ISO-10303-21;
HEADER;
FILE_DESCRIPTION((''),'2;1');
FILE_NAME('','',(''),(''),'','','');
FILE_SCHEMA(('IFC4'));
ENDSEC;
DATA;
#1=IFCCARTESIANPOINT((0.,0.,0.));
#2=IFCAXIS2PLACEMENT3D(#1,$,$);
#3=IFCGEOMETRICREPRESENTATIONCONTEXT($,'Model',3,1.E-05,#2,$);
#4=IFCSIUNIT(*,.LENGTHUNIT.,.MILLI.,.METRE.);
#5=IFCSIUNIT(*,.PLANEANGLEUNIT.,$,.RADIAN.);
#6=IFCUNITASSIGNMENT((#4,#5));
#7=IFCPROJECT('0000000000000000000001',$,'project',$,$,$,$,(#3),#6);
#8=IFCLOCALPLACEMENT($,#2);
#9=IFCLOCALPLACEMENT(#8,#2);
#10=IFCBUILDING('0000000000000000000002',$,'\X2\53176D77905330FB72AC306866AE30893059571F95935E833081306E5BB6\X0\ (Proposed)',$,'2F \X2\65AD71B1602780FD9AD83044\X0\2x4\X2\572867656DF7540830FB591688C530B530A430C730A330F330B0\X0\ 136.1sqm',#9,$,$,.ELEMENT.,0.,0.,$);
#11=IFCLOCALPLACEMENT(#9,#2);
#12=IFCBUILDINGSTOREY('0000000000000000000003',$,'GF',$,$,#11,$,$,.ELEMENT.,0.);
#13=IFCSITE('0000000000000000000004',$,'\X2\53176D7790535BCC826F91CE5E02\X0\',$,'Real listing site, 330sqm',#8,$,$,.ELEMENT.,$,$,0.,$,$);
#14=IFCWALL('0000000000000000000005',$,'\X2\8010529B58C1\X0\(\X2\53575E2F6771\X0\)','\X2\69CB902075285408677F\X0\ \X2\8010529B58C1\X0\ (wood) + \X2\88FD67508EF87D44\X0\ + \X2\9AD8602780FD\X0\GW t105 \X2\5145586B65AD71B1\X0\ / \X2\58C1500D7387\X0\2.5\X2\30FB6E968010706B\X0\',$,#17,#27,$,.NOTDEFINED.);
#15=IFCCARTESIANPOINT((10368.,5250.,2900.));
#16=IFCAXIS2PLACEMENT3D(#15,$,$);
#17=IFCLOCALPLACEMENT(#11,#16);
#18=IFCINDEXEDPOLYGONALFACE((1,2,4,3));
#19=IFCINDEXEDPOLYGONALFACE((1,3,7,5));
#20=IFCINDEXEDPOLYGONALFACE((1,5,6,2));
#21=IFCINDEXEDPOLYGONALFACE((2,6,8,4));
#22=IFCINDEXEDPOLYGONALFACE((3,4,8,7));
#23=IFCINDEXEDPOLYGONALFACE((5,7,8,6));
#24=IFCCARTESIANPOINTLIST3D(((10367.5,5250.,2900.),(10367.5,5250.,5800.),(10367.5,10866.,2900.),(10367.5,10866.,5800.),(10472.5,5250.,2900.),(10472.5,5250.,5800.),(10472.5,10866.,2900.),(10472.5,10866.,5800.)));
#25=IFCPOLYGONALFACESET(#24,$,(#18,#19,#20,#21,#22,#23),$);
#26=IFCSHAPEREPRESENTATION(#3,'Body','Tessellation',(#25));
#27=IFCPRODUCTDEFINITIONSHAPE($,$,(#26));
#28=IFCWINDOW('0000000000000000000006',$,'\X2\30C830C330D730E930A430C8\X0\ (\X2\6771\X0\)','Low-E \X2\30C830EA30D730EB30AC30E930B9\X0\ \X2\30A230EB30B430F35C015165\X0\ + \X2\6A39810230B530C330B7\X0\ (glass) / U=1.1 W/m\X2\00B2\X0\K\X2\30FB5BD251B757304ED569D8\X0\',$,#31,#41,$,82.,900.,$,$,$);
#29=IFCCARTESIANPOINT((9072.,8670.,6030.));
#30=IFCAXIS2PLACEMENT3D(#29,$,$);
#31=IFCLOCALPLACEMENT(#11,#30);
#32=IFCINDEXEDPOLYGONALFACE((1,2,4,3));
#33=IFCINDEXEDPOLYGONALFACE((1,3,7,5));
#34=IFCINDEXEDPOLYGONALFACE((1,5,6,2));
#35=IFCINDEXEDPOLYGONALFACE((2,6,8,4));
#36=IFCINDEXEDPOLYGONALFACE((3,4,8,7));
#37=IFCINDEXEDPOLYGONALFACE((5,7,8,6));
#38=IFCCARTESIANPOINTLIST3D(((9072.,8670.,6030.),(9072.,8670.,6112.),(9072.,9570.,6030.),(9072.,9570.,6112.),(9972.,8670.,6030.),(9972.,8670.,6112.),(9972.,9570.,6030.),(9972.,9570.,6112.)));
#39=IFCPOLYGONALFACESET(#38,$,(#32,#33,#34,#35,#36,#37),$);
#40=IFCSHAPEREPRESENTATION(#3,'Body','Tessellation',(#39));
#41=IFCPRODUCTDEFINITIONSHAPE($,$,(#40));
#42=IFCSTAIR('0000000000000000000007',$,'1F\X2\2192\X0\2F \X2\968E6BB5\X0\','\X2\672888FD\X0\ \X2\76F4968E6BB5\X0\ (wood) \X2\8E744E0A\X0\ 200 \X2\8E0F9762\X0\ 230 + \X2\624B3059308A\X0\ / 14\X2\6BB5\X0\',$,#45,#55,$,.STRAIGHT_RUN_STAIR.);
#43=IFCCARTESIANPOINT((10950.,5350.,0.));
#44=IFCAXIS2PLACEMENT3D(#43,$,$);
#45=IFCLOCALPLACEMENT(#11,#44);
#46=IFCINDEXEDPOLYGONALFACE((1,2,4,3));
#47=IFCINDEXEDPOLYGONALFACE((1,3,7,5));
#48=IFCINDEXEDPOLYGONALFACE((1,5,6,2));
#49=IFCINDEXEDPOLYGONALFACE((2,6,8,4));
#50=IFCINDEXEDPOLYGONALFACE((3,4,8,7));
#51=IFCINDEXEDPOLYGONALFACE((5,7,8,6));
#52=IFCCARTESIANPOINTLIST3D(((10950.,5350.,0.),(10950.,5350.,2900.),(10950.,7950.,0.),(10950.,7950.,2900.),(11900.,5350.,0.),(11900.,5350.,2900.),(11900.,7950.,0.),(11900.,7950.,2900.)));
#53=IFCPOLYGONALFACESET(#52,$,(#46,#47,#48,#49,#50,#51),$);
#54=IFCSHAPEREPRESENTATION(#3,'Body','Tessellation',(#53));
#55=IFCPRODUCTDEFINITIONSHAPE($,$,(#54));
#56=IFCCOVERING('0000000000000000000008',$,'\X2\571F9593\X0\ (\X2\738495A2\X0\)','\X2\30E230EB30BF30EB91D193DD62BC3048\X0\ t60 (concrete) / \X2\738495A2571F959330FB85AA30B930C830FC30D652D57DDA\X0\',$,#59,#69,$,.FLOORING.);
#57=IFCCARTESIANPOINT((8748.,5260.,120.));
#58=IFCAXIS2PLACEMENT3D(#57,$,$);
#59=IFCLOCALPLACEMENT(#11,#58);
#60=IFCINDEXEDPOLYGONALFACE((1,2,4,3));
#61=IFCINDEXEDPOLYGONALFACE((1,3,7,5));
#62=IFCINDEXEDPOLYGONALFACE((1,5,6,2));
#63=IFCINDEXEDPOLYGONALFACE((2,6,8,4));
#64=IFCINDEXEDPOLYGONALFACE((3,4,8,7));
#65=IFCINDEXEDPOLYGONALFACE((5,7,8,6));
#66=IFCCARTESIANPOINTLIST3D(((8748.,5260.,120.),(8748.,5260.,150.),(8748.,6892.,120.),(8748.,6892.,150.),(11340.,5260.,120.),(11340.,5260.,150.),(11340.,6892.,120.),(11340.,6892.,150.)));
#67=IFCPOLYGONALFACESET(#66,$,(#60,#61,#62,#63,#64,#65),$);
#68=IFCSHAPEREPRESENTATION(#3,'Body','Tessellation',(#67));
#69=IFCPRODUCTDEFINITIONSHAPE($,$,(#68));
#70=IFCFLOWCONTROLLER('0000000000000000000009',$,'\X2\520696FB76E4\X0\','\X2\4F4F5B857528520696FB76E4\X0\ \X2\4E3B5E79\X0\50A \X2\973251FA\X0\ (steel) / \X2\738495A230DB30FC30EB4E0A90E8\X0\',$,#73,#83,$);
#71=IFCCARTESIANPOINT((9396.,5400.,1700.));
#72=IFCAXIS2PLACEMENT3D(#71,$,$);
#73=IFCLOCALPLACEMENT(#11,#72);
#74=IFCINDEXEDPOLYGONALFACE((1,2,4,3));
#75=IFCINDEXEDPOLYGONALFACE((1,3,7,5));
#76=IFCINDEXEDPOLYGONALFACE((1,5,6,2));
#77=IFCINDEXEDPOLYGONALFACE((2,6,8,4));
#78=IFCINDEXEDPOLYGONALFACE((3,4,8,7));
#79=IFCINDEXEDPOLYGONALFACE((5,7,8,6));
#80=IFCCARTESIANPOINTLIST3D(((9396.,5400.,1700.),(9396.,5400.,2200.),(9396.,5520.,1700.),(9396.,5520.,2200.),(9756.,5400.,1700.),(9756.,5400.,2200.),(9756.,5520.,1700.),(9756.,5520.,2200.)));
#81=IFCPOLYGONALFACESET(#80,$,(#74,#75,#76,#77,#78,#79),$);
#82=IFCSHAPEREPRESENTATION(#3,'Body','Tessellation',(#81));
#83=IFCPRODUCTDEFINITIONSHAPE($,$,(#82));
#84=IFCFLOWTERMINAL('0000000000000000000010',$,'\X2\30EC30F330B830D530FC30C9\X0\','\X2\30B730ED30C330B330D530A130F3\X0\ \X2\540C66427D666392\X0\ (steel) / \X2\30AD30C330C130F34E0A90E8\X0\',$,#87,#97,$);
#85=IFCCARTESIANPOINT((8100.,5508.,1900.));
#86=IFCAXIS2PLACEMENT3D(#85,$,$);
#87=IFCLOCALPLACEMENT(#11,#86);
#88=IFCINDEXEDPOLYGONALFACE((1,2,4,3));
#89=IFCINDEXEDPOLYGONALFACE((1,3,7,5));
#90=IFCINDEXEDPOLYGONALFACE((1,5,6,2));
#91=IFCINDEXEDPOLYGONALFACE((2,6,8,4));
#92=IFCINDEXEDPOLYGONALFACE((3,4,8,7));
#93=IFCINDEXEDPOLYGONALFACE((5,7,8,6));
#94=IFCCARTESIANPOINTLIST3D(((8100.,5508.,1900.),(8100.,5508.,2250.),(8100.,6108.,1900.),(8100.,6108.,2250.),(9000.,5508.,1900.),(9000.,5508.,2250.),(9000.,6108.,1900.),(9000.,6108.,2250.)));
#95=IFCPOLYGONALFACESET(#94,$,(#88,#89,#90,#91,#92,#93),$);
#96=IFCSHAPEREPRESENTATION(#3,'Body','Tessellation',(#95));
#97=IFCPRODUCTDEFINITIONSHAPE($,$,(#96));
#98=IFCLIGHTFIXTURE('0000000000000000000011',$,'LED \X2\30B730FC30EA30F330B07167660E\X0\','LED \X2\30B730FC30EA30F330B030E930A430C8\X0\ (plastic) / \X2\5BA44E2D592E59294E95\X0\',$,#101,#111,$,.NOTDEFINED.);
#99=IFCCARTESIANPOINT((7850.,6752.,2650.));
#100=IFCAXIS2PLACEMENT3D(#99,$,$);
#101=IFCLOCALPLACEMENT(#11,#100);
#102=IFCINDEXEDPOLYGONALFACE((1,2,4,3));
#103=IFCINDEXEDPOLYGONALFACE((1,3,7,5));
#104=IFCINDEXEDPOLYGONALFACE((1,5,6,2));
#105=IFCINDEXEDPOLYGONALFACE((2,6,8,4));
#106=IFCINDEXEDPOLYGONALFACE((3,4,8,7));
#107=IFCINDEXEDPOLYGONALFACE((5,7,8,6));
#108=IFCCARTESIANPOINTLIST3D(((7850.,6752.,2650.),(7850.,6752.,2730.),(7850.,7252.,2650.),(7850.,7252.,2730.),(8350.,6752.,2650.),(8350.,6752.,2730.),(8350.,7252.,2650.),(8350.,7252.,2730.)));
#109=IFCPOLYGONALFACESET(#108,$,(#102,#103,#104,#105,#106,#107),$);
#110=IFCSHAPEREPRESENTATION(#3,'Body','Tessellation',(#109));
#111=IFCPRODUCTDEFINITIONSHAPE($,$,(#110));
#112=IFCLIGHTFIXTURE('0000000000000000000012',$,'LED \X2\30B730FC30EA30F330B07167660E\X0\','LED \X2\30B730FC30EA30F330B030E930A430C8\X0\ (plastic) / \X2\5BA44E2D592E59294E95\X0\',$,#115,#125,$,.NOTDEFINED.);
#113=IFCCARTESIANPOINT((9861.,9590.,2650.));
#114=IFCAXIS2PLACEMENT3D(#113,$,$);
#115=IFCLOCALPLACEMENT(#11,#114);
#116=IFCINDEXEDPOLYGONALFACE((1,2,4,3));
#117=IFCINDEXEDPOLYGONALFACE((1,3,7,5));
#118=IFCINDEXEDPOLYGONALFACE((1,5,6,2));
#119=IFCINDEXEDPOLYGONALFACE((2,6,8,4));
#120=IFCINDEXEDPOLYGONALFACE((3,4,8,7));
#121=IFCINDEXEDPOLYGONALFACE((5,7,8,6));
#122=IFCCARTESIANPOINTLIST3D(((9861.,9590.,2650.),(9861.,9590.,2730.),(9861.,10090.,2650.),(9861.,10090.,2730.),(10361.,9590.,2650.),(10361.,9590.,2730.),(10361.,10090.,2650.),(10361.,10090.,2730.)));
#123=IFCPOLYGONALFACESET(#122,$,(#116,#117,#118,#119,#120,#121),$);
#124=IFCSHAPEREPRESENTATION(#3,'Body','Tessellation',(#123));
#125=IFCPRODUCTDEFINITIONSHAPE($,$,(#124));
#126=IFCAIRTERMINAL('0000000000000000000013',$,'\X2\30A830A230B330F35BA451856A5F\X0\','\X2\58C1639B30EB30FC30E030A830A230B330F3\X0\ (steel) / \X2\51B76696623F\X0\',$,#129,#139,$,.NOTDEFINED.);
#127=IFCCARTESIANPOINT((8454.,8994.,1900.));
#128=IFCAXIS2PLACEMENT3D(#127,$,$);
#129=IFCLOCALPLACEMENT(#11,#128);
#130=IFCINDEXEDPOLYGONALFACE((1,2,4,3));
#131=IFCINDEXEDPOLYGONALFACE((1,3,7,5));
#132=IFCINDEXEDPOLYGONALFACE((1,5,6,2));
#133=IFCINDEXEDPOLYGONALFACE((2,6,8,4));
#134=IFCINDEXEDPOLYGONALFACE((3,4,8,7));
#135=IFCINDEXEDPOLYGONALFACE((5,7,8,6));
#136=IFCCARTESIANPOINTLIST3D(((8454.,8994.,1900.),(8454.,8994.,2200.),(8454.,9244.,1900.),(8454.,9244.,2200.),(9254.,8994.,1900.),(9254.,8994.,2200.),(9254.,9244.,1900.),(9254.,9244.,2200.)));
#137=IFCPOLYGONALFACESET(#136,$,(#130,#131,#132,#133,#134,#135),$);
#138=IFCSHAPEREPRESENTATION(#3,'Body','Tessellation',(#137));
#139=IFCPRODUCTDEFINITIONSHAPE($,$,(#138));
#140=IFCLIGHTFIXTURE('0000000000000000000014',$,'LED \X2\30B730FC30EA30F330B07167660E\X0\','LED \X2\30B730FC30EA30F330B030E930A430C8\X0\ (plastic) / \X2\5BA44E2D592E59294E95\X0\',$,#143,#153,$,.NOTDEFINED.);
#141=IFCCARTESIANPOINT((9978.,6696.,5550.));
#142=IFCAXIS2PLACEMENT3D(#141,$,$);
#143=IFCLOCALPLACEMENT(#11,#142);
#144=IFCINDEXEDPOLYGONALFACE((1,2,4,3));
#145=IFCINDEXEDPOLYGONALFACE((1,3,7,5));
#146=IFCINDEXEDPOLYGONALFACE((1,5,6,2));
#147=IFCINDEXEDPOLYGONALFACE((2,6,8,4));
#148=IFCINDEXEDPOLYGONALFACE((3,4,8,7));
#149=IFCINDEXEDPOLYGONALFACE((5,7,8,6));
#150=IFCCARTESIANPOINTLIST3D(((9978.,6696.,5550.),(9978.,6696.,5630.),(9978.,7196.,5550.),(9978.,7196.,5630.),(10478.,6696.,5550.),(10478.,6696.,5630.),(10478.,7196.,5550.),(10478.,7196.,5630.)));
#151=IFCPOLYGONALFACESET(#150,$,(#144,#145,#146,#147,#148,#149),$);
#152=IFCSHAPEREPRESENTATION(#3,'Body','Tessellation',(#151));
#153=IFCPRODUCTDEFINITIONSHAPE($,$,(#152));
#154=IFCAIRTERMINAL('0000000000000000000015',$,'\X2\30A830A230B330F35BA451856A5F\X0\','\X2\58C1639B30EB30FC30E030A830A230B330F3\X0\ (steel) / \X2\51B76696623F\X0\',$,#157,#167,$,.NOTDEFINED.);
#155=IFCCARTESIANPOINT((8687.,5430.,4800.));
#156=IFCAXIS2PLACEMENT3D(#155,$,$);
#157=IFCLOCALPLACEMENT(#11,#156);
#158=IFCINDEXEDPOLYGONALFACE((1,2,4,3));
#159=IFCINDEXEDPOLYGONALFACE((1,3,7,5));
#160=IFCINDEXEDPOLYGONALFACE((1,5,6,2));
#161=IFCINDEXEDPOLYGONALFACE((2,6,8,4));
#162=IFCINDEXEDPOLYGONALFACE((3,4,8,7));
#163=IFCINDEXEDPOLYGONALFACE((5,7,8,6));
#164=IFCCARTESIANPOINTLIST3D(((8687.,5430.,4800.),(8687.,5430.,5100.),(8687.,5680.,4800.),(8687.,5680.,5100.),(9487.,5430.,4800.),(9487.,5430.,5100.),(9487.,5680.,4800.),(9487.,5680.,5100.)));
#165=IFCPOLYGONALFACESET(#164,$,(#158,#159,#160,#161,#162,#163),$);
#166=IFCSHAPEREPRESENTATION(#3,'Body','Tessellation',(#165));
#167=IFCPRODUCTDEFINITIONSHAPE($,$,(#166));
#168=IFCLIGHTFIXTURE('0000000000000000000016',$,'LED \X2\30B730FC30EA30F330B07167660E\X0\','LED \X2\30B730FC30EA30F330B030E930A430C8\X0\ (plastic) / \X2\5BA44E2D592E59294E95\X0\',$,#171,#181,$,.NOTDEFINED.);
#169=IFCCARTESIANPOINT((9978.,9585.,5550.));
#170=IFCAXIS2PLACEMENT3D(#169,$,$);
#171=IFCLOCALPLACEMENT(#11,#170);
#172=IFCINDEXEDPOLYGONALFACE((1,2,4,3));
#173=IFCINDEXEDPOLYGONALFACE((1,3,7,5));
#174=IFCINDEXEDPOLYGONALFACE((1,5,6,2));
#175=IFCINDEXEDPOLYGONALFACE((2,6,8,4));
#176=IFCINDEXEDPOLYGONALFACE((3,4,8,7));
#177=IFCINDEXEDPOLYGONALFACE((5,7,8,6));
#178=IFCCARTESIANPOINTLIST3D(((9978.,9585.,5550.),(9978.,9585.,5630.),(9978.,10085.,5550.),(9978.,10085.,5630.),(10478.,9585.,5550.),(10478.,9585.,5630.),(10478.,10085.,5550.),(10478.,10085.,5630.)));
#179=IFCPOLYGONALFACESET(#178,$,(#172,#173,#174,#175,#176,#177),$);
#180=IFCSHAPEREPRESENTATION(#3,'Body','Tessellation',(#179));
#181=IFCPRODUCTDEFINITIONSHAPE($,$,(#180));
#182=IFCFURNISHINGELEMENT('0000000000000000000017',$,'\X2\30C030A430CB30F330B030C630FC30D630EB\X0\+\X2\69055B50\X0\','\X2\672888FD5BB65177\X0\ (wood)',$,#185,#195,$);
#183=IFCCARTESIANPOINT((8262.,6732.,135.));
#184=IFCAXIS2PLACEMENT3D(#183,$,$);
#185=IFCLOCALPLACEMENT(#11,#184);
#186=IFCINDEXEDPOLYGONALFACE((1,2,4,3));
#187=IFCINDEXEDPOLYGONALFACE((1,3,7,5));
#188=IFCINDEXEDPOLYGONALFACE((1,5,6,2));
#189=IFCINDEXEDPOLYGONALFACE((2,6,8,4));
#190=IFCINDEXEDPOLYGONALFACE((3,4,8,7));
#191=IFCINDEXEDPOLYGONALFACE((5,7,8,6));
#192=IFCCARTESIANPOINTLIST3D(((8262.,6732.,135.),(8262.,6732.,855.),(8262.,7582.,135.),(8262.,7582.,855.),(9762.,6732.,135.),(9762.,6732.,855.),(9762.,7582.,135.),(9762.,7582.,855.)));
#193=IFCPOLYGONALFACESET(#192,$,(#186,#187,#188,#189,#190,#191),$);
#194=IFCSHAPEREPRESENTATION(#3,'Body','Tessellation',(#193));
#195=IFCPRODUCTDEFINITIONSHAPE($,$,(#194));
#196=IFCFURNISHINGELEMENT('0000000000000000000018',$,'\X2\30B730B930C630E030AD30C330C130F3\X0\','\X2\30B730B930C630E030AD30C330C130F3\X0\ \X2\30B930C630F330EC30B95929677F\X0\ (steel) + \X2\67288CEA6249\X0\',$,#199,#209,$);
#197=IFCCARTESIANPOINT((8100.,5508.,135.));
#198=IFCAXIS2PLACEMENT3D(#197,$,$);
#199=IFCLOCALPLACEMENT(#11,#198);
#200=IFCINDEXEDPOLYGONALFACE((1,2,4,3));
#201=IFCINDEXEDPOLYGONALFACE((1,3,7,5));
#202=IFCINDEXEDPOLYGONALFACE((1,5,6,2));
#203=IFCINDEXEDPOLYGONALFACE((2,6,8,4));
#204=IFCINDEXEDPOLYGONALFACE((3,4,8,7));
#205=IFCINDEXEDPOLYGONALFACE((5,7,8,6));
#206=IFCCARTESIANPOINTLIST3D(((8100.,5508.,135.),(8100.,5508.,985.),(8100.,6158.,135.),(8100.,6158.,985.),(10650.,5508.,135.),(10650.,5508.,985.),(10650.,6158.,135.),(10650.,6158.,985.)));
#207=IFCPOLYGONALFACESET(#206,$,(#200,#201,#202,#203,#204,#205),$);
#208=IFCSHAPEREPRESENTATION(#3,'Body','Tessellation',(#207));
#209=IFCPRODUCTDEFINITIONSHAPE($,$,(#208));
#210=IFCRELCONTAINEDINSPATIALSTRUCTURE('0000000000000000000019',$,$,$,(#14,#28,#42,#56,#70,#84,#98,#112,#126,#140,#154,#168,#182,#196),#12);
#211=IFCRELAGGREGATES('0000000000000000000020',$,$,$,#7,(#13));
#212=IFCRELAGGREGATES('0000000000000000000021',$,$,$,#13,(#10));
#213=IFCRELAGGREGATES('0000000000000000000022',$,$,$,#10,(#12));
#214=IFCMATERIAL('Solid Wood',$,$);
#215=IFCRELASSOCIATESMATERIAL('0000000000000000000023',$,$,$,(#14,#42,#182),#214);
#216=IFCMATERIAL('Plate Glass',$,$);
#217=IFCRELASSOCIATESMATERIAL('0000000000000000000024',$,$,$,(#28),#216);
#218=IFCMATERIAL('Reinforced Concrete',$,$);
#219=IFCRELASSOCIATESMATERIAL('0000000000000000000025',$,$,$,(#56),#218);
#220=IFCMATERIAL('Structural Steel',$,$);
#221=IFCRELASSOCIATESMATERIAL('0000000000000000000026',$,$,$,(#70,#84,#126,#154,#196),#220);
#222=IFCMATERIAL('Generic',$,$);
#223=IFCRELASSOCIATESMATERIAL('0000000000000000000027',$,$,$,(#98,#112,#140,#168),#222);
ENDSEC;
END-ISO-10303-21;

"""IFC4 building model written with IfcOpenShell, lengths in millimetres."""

from ifc_helpers import new_model, si_unit, frame, frame_2d, origin, place, context, project, spatial, rectangle, extrude, material, element, save


model = new_model("IFC4")

# Units and contexts
model_context = context("Model", 3, precision=1e-05, world=origin())
ifc_project = project(units=[si_unit("LENGTHUNIT", "METRE", prefix="MILLI"), si_unit("PLANEANGLEUNIT", "RADIAN")], contexts=[model_context])

# Site, building, storey
site_placement = place(None, origin())
site = spatial("IfcSite", under=ifc_project, at=site_placement, Name="北海道富良野市", ObjectType="Real listing site, 330sqm", CompositionType="ELEMENT", RefElevation=0.0)
building_placement = place(site_placement, origin())
building = spatial("IfcBuilding", under=site, at=building_placement, Name="北海道・犬と暮らす土間広めの家 (Proposed)", ObjectType="2F 断熱性能高い2x4在来混合・外装サイディング 136.1sqm", CompositionType="ELEMENT", ElevationOfRefHeight=0.0, ElevationOfTerrain=0.0)
storey_placement = place(building_placement, origin())
storey = spatial("IfcBuildingStorey", under=building, at=storey_placement, Name="GF", CompositionType="ELEMENT", Elevation=0.0)

# Shared definitions
ifc_material_1 = material(Name="Solid Wood")

# Wall
wall_1_placement = place(storey_placement, frame((10368.0, 5250.0, 2900.0)))
element("IfcWall", 1, at=wall_1_placement, inside=storey, material=ifc_material_1, Name="耐力壁(南帯東)", Description="構造用合板 耐力壁 (wood) + 製材軸組 + 高性能GW t105 充填断熱 / 壁倍率2.5・準耐火", PredefinedType="NOTDEFINED", context=model_context, shape_type="SweptSolid", body=[
    extrude(rectangle(XDim=105.0, YDim=5616.0, at=frame_2d((52.0, 2808.0))), frame((10368.0, 5250.0, 2900.0)), (0.0, 0.0, 1.0), 2900.0),
])

# Window
ifc_material_2 = material(Name="Plate Glass")
window_placement = place(storey_placement, frame((9072.0, 8670.0, 6030.0)))
element("IfcWindow", 2, at=window_placement, inside=storey, material=ifc_material_2, Name="トップライト (東)", Description="Low-E トリプルガラス アルゴン封入 + 樹脂サッシ (glass) / U=1.1 W/m²K・寒冷地仕様", OverallHeight=82.0, OverallWidth=900.0, context=model_context, shape_type="SweptSolid", body=[
    extrude(rectangle(XDim=900.0, YDim=900.0, at=frame_2d((450.0, 450.0))), frame((9072.0, 8670.0, 6030.0)), (0.0, 0.0, 1.0), 82.0),
])

# Stair
stair_placement = place(storey_placement, frame((10950.0, 5350.0, 0.0)))
element("IfcStair", 3, at=stair_placement, inside=storey, material=ifc_material_1, Name="1F→2F 階段", Description="木製 直階段 (wood) 蹴上 200 踏面 230 + 手すり / 14段", PredefinedType="STRAIGHT_RUN_STAIR", context=model_context, shape_type="SweptSolid", body=[
    extrude(rectangle(XDim=950.0, YDim=2600.0, at=frame_2d((475.0, 1300.0))), frame((10950.0, 5350.0, 0.0)), (0.0, 0.0, 1.0), 2900.0),
])

# Covering
ifc_material_3 = material(Name="Reinforced Concrete")
covering_placement = place(storey_placement, frame((8748.0, 5260.0, 120.0)))
element("IfcCovering", 4, at=covering_placement, inside=storey, material=ifc_material_3, Name="土間 (玄関)", Description="モルタル金鏝押え t60 (concrete) / 玄関土間・薪ストーブ動線", PredefinedType="FLOORING", context=model_context, shape_type="SweptSolid", body=[
    extrude(rectangle(XDim=2592.0, YDim=1632.0, at=frame_2d((1296.0, 816.0))), frame((8748.0, 5260.0, 120.0)), (0.0, 0.0, 1.0), 30.0),
])

# Flow controller
ifc_material_4 = material(Name="Structural Steel")
flow_controller_placement = place(storey_placement, frame((9396.0, 5400.0, 1700.0)))
element("IfcFlowController", 5, at=flow_controller_placement, inside=storey, material=ifc_material_4, Name="分電盤", Description="住宅用分電盤 主幹50A 露出 (steel) / 玄関ホール上部", context=model_context, shape_type="SweptSolid", body=[
    extrude(rectangle(XDim=360.0, YDim=120.0, at=frame_2d((180.0, 60.0))), frame((9396.0, 5400.0, 1700.0)), (0.0, 0.0, 1.0), 500.0),
])

# Flow terminal
flow_terminal_placement = place(storey_placement, frame((8100.0, 5508.0, 1900.0)))
element("IfcFlowTerminal", 6, at=flow_terminal_placement, inside=storey, material=ifc_material_4, Name="レンジフード", Description="シロッコファン 同時給排 (steel) / キッチン上部", context=model_context, shape_type="SweptSolid", body=[
    extrude(rectangle(XDim=900.0, YDim=600.0, at=frame_2d((450.0, 300.0))), frame((8100.0, 5508.0, 1900.0)), (0.0, 0.0, 1.0), 350.0),
])

# Light fixtures
ifc_material_5 = material(Name="Generic")
light_fixture_1_placement = place(storey_placement, frame((7850.0, 6752.0, 2650.0)))
element("IfcLightFixture", 7, at=light_fixture_1_placement, inside=storey, material=ifc_material_5, Name="LED シーリング照明", Description="LED シーリングライト (plastic) / 室中央天井", PredefinedType="NOTDEFINED", context=model_context, shape_type="SweptSolid", body=[
    extrude(rectangle(XDim=500.0, YDim=500.0, at=frame_2d((250.0, 250.0))), frame((7850.0, 6752.0, 2650.0)), (0.0, 0.0, 1.0), 80.0),
])
light_fixture_2_placement = place(storey_placement, frame((9861.0, 9590.0, 2650.0)))
element("IfcLightFixture", 8, at=light_fixture_2_placement, inside=storey, material=ifc_material_5, Name="LED シーリング照明", Description="LED シーリングライト (plastic) / 室中央天井", PredefinedType="NOTDEFINED", context=model_context, shape_type="SweptSolid", body=[
    extrude(rectangle(XDim=500.0, YDim=500.0, at=frame_2d((250.0, 250.0))), frame((9861.0, 9590.0, 2650.0)), (0.0, 0.0, 1.0), 80.0),
])

# Air terminal
air_terminal_1_placement = place(storey_placement, frame((8454.0, 8994.0, 1900.0)))
element("IfcAirTerminal", 9, at=air_terminal_1_placement, inside=storey, material=ifc_material_4, Name="エアコン室内機", Description="壁掛ルームエアコン (steel) / 冷暖房", PredefinedType="NOTDEFINED", context=model_context, shape_type="SweptSolid", body=[
    extrude(rectangle(XDim=800.0, YDim=250.0, at=frame_2d((400.0, 125.0))), frame((8454.0, 8994.0, 1900.0)), (0.0, 0.0, 1.0), 300.0),
])

# Light fixture
light_fixture_3_placement = place(storey_placement, frame((9978.0, 6696.0, 5550.0)))
element("IfcLightFixture", 10, at=light_fixture_3_placement, inside=storey, material=ifc_material_5, Name="LED シーリング照明", Description="LED シーリングライト (plastic) / 室中央天井", PredefinedType="NOTDEFINED", context=model_context, shape_type="SweptSolid", body=[
    extrude(rectangle(XDim=500.0, YDim=500.0, at=frame_2d((250.0, 250.0))), frame((9978.0, 6696.0, 5550.0)), (0.0, 0.0, 1.0), 80.0),
])

# Air terminal
air_terminal_2_placement = place(storey_placement, frame((8687.0, 5430.0, 4800.0)))
element("IfcAirTerminal", 11, at=air_terminal_2_placement, inside=storey, material=ifc_material_4, Name="エアコン室内機", Description="壁掛ルームエアコン (steel) / 冷暖房", PredefinedType="NOTDEFINED", context=model_context, shape_type="SweptSolid", body=[
    extrude(rectangle(XDim=800.0, YDim=250.0, at=frame_2d((400.0, 125.0))), frame((8687.0, 5430.0, 4800.0)), (0.0, 0.0, 1.0), 300.0),
])

# Light fixture
light_fixture_4_placement = place(storey_placement, frame((9978.0, 9585.0, 5550.0)))
element("IfcLightFixture", 12, at=light_fixture_4_placement, inside=storey, material=ifc_material_5, Name="LED シーリング照明", Description="LED シーリングライト (plastic) / 室中央天井", PredefinedType="NOTDEFINED", context=model_context, shape_type="SweptSolid", body=[
    extrude(rectangle(XDim=500.0, YDim=500.0, at=frame_2d((250.0, 250.0))), frame((9978.0, 9585.0, 5550.0)), (0.0, 0.0, 1.0), 80.0),
])

# Furnishing elements
furnishing_1_placement = place(storey_placement, frame((8262.0, 6732.0, 135.0)))
element("IfcFurnishingElement", 13, at=furnishing_1_placement, inside=storey, material=ifc_material_1, Name="ダイニングテーブル+椅子", Description="木製家具 (wood)", context=model_context, shape_type="SweptSolid", body=[
    extrude(rectangle(XDim=1500.0, YDim=850.0, at=frame_2d((750.0, 425.0))), frame((8262.0, 6732.0, 135.0)), (0.0, 0.0, 1.0), 720.0),
])
furnishing_2_placement = place(storey_placement, frame((8100.0, 5508.0, 135.0)))
element("IfcFurnishingElement", 14, at=furnishing_2_placement, inside=storey, material=ifc_material_4, Name="システムキッチン", Description="システムキッチン ステンレス天板 (steel) + 木質扉", context=model_context, shape_type="SweptSolid", body=[
    extrude(rectangle(XDim=2550.0, YDim=650.0, at=frame_2d((1275.0, 325.0))), frame((8100.0, 5508.0, 135.0)), (0.0, 0.0, 1.0), 850.0),
])

save(model, "model.ifc")
